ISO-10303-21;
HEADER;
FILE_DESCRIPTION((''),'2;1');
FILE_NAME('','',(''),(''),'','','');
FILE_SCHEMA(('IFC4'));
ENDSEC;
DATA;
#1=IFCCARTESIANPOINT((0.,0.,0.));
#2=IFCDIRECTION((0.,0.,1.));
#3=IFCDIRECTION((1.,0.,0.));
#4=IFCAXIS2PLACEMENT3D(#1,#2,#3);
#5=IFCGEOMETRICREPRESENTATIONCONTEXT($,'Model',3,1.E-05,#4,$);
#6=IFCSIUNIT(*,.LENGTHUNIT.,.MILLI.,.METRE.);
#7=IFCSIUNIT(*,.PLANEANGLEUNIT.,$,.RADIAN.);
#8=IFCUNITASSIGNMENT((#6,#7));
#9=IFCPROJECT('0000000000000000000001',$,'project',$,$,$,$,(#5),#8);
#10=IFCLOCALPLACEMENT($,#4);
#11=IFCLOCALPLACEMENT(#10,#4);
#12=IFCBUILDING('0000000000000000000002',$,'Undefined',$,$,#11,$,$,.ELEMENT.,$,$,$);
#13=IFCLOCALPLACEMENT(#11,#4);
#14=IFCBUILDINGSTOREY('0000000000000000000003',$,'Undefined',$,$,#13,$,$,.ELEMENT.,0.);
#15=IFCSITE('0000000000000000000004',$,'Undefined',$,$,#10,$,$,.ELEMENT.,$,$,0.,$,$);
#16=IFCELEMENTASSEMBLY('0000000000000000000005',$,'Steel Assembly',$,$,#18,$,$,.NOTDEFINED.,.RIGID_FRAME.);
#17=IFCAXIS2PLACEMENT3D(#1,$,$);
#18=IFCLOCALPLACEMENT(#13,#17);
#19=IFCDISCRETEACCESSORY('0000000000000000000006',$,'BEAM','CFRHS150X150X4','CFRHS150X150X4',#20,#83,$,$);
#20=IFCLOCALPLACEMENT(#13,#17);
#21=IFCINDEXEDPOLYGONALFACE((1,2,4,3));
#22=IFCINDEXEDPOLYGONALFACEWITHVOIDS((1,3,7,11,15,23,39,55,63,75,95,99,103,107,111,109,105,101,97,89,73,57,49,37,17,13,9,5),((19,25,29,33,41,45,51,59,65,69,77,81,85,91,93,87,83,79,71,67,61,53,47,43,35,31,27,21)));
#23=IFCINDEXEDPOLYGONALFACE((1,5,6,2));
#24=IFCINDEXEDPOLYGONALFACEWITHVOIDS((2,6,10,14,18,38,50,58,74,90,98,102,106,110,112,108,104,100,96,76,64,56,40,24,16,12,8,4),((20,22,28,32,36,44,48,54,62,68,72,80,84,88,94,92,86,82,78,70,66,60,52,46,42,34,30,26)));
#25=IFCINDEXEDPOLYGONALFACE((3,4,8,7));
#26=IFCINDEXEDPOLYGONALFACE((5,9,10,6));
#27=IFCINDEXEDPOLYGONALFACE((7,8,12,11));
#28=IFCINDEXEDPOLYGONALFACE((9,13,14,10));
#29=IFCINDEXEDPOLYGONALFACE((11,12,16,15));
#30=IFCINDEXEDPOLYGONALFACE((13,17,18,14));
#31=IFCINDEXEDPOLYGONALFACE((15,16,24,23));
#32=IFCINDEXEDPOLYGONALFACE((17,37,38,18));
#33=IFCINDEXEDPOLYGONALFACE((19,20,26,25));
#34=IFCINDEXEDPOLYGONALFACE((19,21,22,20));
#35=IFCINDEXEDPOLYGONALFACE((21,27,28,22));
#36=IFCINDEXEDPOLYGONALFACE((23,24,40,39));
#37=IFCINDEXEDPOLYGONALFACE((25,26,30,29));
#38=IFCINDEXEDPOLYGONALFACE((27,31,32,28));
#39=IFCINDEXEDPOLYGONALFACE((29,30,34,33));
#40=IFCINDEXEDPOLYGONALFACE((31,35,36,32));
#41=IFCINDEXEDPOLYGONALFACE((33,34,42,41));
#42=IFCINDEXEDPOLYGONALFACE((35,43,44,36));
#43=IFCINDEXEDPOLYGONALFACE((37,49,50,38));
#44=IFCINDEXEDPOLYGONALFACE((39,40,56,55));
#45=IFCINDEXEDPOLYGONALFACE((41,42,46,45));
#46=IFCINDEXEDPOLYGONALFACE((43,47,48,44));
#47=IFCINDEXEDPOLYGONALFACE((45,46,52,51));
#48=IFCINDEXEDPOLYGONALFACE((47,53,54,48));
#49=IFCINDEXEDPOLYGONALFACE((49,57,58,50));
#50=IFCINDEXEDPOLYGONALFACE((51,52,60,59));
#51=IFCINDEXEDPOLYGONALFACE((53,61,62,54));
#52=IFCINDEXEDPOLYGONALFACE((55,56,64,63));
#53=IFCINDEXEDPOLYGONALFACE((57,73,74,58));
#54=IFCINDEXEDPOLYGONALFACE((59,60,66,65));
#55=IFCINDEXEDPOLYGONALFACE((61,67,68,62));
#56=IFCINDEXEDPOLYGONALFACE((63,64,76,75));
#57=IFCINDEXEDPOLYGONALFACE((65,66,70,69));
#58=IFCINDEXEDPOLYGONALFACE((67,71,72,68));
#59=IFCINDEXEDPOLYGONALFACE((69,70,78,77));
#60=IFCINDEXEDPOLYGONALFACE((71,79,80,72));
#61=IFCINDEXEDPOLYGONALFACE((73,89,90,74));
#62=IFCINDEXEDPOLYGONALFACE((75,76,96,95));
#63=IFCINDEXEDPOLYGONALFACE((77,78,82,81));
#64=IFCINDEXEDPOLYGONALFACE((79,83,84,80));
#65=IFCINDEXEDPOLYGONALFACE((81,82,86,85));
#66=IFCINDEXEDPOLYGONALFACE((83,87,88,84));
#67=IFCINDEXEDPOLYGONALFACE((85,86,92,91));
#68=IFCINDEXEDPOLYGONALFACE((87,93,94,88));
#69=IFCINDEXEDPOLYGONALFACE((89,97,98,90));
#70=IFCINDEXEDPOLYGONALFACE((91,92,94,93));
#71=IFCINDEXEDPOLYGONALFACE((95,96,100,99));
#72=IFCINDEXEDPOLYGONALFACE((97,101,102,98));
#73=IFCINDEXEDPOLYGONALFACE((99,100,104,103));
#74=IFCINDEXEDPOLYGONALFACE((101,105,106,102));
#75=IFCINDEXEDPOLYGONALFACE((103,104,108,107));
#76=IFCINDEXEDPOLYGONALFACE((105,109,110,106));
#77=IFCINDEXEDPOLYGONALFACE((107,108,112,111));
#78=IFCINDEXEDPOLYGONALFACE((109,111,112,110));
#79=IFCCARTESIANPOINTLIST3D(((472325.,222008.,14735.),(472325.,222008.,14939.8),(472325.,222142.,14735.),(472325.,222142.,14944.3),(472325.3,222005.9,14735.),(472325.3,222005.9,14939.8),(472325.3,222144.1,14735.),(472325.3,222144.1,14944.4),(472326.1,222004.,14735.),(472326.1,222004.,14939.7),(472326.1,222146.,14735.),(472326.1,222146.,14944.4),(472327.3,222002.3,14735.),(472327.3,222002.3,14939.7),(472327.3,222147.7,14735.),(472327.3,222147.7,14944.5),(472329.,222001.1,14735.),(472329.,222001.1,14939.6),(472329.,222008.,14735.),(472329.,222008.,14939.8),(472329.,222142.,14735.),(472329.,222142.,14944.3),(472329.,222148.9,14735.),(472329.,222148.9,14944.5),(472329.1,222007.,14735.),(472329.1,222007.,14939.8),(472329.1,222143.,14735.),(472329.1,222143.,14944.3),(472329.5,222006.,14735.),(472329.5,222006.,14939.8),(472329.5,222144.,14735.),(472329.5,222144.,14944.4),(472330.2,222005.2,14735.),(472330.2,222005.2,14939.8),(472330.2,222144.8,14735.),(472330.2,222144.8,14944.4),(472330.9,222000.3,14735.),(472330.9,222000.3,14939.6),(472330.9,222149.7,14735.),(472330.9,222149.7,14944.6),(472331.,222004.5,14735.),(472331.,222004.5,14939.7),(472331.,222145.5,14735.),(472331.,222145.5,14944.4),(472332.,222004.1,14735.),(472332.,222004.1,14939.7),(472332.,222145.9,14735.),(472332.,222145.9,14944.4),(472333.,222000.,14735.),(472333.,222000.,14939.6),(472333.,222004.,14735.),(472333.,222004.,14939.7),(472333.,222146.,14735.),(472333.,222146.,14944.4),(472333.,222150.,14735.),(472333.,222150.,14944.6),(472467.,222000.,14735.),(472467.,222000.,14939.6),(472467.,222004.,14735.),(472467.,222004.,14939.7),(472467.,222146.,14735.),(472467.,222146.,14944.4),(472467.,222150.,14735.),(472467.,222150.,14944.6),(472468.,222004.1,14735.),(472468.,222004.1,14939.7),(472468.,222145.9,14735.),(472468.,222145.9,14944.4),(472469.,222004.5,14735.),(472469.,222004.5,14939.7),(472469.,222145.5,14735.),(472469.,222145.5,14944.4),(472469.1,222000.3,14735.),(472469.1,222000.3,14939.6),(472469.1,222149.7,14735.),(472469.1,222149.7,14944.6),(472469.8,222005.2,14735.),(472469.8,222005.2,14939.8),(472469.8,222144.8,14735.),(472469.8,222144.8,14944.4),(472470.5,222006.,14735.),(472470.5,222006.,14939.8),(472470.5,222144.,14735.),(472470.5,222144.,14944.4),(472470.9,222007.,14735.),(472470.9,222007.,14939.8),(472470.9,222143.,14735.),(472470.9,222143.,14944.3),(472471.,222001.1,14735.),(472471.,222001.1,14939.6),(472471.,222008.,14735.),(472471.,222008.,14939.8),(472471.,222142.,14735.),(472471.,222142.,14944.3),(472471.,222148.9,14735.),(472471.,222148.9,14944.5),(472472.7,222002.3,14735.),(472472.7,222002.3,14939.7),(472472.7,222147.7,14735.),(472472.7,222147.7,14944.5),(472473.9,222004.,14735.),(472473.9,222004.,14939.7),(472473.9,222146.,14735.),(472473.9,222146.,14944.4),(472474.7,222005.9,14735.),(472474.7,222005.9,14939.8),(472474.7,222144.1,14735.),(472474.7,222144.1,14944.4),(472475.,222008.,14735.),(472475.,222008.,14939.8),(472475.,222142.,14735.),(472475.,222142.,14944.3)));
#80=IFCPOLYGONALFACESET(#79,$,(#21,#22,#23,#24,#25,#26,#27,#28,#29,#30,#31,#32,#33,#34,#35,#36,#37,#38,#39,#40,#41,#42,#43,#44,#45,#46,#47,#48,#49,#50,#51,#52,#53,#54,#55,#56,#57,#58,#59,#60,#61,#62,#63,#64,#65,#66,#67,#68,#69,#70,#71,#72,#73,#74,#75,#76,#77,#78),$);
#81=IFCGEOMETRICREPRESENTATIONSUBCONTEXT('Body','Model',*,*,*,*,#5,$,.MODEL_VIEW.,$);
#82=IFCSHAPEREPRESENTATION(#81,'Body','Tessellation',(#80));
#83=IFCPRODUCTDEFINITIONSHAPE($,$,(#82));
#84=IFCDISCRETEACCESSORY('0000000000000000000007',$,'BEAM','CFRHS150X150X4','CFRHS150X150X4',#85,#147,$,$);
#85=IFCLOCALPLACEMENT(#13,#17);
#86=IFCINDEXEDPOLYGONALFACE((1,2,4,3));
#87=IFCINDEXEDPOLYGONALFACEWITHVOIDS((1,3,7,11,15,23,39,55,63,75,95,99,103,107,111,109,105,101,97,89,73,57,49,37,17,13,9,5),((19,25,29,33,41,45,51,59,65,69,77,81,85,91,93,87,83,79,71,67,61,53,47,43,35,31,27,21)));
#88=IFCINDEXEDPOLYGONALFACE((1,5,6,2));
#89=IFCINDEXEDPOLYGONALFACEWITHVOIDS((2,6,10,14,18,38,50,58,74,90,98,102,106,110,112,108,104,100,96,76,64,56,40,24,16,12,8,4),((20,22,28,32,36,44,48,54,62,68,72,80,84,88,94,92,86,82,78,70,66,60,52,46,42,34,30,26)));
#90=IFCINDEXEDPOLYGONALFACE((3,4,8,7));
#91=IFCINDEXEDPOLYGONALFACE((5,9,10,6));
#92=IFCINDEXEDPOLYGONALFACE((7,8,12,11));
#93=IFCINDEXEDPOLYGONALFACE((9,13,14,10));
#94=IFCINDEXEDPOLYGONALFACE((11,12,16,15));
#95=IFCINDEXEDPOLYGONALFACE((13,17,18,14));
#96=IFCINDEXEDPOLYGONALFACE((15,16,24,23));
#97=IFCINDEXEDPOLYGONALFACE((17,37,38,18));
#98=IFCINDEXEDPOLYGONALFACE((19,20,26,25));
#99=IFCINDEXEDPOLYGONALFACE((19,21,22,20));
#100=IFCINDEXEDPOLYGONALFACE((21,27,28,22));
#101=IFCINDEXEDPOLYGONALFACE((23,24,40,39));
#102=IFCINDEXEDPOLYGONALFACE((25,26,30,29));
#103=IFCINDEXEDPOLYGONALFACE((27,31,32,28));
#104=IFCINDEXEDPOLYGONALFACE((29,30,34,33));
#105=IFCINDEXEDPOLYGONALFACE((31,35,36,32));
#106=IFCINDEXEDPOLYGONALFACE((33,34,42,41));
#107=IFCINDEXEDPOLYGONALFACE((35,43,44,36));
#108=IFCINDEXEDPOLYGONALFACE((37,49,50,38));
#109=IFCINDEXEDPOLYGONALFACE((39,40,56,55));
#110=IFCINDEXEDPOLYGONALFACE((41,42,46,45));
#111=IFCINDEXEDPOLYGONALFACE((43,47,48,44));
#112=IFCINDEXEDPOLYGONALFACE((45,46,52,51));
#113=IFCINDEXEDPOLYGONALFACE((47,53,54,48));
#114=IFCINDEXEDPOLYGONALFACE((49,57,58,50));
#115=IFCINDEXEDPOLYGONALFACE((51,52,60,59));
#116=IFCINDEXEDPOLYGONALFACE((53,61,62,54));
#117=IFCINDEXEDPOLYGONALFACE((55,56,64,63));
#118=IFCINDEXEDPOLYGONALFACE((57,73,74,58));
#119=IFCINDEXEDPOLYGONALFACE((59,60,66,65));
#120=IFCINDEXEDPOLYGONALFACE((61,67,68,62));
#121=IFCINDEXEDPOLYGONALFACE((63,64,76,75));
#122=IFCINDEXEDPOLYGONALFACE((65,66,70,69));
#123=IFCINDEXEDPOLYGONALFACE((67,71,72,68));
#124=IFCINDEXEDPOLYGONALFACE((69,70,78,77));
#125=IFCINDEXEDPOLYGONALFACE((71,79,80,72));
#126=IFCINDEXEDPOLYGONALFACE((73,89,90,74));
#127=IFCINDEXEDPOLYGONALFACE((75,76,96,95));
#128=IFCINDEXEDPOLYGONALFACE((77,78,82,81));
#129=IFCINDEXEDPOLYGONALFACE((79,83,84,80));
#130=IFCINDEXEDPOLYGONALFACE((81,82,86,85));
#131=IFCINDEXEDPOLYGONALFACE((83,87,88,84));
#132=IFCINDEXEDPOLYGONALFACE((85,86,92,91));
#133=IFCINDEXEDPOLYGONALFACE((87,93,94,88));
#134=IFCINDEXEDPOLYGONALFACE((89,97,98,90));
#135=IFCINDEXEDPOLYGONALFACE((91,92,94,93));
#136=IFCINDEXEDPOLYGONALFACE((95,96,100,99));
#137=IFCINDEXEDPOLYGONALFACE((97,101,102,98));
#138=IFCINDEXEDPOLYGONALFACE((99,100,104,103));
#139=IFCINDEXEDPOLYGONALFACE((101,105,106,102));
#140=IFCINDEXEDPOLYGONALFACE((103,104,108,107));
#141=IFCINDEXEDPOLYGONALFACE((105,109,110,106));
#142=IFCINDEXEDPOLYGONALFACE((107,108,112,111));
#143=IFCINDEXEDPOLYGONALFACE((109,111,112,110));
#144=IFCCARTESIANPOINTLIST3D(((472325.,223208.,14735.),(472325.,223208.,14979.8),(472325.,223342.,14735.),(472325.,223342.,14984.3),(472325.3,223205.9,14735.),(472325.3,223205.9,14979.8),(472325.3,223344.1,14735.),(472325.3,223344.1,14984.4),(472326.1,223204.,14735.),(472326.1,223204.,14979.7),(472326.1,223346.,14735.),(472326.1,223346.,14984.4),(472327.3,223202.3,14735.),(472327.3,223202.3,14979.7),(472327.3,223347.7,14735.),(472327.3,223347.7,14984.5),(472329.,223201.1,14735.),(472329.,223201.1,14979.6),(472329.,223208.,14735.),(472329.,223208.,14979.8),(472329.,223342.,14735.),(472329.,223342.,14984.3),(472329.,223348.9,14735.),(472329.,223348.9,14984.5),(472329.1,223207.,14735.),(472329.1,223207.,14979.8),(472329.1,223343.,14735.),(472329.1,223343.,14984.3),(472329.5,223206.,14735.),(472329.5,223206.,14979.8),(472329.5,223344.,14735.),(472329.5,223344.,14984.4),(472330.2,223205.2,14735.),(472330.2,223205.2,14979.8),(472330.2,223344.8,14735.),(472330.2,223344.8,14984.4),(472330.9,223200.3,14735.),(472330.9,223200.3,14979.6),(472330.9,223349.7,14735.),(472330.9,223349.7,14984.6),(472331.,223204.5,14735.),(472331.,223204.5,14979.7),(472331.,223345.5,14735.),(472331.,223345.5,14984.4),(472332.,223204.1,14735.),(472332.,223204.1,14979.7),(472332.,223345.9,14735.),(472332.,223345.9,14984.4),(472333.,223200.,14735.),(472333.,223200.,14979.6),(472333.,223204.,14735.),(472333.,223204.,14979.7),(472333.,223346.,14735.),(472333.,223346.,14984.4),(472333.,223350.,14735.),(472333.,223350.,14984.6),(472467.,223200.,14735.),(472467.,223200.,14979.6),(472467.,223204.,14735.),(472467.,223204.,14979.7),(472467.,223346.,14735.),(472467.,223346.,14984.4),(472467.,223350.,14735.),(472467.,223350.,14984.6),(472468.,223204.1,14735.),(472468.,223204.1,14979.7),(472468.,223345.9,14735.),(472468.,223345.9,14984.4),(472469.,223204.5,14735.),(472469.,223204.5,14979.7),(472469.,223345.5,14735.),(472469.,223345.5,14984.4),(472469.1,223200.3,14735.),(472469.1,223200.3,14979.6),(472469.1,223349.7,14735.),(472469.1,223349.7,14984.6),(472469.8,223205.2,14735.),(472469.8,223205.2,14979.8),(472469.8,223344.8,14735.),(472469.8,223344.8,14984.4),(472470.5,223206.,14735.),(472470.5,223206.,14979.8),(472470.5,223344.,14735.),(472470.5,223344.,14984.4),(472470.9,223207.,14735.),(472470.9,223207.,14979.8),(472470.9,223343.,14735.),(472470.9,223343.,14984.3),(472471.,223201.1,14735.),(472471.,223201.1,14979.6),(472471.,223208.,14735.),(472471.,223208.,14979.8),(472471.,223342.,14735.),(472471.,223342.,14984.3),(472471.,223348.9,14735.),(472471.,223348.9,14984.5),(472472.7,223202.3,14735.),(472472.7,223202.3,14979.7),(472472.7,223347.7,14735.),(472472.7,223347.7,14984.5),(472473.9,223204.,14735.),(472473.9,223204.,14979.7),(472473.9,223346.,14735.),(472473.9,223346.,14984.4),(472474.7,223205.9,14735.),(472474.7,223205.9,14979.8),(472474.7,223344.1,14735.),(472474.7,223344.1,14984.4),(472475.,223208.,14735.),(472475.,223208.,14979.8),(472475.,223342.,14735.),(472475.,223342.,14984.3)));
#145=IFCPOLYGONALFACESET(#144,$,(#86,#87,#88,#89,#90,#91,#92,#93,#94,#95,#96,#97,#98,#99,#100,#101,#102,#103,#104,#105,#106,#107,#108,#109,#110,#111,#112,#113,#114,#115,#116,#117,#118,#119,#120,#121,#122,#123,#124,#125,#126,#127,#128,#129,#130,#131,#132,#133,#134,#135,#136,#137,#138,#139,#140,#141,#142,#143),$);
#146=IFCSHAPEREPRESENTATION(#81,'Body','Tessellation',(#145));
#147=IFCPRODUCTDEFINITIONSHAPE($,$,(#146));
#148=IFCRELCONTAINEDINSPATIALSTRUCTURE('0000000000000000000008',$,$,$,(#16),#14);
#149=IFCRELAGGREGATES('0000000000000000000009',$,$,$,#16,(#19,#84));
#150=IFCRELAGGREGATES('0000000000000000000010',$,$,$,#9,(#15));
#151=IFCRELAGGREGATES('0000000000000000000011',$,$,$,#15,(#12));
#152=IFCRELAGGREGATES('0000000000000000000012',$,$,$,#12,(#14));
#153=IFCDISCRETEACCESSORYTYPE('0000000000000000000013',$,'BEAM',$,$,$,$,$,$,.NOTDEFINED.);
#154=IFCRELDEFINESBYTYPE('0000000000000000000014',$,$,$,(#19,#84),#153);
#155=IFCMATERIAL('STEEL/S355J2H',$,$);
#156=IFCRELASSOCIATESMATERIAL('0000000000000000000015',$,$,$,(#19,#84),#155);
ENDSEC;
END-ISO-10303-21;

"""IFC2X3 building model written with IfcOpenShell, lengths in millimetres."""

from ifc_helpers import new_model, si_unit, frame, origin_with_axes, origin_2d_with_axis, place, context, subcontext, project, spatial, hollow_rectangle, extrude, clip, halfspace, material, type_object, element, aggregate, save


model = new_model("IFC2X3")

# Units and contexts
model_context = context("Model", 3, precision=1e-05, world=origin_with_axes())
body_context = subcontext(model_context, "Body", "Model", "MODEL_VIEW")
ifc_project = project(units=[si_unit("LENGTHUNIT", "METRE", prefix="MILLI"), si_unit("PLANEANGLEUNIT", "RADIAN")], contexts=[model_context])

# Site, building, storey
site_placement = place(None, origin_with_axes())
site = spatial("IfcSite", under=ifc_project, at=site_placement, Name="Undefined", CompositionType="ELEMENT", RefElevation=0.0)
building_placement = place(site_placement, origin_with_axes())
building = spatial("IfcBuilding", under=site, at=building_placement, Name="Undefined", CompositionType="ELEMENT")
storey_placement = place(building_placement, origin_with_axes())
storey = spatial("IfcBuildingStorey", under=building, at=storey_placement, Name="Undefined", CompositionType="ELEMENT", Elevation=0.0)

# Element assembly, discrete accessories
assembly_1_placement = place(storey_placement, origin_with_axes())
assembly_1 = element("IfcElementAssembly", 1, at=assembly_1_placement, inside=storey, Name="Steel Assembly", AssemblyPlace="NOTDEFINED", PredefinedType="RIGID_FRAME")
ifc_material_1 = material(Name="STEEL/S355J2H")
discrete_accessory_type_1 = type_object("IfcDiscreteAccessoryType", Name="BEAM")
discrete_accessory_1_placement = place(assembly_1_placement, frame((472400.0, 222075.0, 14720.0), z_axis=(0.0, 0.0, 1.0), x_axis=(1.0, 0.0, 0.0)))
discrete_accessory_1 = element("IfcDiscreteAccessory", 2, at=discrete_accessory_1_placement, type_object=discrete_accessory_type_1, material=ifc_material_1, Name="BEAM", Description="CFRHS150X150X4", ObjectType="CFRHS150X150X4", context=body_context, shape_type="Clipping", body=[
    clip(extrude(hollow_rectangle(XDim=150.0, YDim=150.0, WallThickness=4.0, InnerFilletRadius=4.0, OuterFilletRadius=8.0, at=origin_2d_with_axis()), frame((0.0, 0.0, 224.6), z_axis=(0.0, 0.0, -1.0), x_axis=(0.0, -1.0, 0.0)), (0.0, 0.0, 1.0), 209.6), halfspace(frame((-1000.0, 2.7, 222.2), z_axis=(0.0, 0.033315, -0.999445), x_axis=(0.0, -0.999445, -0.033315)), True)),
])
discrete_accessory_2_placement = place(assembly_1_placement, frame((472400.0, 223275.0, 14720.0), z_axis=(0.0, 0.0, 1.0), x_axis=(1.0, 0.0, 0.0)))
discrete_accessory_2 = element("IfcDiscreteAccessory", 3, at=discrete_accessory_2_placement, type_object=discrete_accessory_type_1, material=ifc_material_1, Name="BEAM", Description="CFRHS150X150X4", ObjectType="CFRHS150X150X4", context=body_context, shape_type="Clipping", body=[
    clip(extrude(hollow_rectangle(XDim=150.0, YDim=150.0, WallThickness=4.0, InnerFilletRadius=4.0, OuterFilletRadius=8.0, at=origin_2d_with_axis()), frame((0.0, 0.0, 264.6), z_axis=(0.0, 0.0, -1.0), x_axis=(0.0, -1.0, 0.0)), (0.0, 0.0, 1.0), 249.6), halfspace(frame((-1000.0, 2.7, 262.2), z_axis=(0.0, 0.033315, -0.999445), x_axis=(0.0, -0.999445, -0.033315)), True)),
])

aggregate(assembly_1, [discrete_accessory_1, discrete_accessory_2])

save(model, "model.ifc")
